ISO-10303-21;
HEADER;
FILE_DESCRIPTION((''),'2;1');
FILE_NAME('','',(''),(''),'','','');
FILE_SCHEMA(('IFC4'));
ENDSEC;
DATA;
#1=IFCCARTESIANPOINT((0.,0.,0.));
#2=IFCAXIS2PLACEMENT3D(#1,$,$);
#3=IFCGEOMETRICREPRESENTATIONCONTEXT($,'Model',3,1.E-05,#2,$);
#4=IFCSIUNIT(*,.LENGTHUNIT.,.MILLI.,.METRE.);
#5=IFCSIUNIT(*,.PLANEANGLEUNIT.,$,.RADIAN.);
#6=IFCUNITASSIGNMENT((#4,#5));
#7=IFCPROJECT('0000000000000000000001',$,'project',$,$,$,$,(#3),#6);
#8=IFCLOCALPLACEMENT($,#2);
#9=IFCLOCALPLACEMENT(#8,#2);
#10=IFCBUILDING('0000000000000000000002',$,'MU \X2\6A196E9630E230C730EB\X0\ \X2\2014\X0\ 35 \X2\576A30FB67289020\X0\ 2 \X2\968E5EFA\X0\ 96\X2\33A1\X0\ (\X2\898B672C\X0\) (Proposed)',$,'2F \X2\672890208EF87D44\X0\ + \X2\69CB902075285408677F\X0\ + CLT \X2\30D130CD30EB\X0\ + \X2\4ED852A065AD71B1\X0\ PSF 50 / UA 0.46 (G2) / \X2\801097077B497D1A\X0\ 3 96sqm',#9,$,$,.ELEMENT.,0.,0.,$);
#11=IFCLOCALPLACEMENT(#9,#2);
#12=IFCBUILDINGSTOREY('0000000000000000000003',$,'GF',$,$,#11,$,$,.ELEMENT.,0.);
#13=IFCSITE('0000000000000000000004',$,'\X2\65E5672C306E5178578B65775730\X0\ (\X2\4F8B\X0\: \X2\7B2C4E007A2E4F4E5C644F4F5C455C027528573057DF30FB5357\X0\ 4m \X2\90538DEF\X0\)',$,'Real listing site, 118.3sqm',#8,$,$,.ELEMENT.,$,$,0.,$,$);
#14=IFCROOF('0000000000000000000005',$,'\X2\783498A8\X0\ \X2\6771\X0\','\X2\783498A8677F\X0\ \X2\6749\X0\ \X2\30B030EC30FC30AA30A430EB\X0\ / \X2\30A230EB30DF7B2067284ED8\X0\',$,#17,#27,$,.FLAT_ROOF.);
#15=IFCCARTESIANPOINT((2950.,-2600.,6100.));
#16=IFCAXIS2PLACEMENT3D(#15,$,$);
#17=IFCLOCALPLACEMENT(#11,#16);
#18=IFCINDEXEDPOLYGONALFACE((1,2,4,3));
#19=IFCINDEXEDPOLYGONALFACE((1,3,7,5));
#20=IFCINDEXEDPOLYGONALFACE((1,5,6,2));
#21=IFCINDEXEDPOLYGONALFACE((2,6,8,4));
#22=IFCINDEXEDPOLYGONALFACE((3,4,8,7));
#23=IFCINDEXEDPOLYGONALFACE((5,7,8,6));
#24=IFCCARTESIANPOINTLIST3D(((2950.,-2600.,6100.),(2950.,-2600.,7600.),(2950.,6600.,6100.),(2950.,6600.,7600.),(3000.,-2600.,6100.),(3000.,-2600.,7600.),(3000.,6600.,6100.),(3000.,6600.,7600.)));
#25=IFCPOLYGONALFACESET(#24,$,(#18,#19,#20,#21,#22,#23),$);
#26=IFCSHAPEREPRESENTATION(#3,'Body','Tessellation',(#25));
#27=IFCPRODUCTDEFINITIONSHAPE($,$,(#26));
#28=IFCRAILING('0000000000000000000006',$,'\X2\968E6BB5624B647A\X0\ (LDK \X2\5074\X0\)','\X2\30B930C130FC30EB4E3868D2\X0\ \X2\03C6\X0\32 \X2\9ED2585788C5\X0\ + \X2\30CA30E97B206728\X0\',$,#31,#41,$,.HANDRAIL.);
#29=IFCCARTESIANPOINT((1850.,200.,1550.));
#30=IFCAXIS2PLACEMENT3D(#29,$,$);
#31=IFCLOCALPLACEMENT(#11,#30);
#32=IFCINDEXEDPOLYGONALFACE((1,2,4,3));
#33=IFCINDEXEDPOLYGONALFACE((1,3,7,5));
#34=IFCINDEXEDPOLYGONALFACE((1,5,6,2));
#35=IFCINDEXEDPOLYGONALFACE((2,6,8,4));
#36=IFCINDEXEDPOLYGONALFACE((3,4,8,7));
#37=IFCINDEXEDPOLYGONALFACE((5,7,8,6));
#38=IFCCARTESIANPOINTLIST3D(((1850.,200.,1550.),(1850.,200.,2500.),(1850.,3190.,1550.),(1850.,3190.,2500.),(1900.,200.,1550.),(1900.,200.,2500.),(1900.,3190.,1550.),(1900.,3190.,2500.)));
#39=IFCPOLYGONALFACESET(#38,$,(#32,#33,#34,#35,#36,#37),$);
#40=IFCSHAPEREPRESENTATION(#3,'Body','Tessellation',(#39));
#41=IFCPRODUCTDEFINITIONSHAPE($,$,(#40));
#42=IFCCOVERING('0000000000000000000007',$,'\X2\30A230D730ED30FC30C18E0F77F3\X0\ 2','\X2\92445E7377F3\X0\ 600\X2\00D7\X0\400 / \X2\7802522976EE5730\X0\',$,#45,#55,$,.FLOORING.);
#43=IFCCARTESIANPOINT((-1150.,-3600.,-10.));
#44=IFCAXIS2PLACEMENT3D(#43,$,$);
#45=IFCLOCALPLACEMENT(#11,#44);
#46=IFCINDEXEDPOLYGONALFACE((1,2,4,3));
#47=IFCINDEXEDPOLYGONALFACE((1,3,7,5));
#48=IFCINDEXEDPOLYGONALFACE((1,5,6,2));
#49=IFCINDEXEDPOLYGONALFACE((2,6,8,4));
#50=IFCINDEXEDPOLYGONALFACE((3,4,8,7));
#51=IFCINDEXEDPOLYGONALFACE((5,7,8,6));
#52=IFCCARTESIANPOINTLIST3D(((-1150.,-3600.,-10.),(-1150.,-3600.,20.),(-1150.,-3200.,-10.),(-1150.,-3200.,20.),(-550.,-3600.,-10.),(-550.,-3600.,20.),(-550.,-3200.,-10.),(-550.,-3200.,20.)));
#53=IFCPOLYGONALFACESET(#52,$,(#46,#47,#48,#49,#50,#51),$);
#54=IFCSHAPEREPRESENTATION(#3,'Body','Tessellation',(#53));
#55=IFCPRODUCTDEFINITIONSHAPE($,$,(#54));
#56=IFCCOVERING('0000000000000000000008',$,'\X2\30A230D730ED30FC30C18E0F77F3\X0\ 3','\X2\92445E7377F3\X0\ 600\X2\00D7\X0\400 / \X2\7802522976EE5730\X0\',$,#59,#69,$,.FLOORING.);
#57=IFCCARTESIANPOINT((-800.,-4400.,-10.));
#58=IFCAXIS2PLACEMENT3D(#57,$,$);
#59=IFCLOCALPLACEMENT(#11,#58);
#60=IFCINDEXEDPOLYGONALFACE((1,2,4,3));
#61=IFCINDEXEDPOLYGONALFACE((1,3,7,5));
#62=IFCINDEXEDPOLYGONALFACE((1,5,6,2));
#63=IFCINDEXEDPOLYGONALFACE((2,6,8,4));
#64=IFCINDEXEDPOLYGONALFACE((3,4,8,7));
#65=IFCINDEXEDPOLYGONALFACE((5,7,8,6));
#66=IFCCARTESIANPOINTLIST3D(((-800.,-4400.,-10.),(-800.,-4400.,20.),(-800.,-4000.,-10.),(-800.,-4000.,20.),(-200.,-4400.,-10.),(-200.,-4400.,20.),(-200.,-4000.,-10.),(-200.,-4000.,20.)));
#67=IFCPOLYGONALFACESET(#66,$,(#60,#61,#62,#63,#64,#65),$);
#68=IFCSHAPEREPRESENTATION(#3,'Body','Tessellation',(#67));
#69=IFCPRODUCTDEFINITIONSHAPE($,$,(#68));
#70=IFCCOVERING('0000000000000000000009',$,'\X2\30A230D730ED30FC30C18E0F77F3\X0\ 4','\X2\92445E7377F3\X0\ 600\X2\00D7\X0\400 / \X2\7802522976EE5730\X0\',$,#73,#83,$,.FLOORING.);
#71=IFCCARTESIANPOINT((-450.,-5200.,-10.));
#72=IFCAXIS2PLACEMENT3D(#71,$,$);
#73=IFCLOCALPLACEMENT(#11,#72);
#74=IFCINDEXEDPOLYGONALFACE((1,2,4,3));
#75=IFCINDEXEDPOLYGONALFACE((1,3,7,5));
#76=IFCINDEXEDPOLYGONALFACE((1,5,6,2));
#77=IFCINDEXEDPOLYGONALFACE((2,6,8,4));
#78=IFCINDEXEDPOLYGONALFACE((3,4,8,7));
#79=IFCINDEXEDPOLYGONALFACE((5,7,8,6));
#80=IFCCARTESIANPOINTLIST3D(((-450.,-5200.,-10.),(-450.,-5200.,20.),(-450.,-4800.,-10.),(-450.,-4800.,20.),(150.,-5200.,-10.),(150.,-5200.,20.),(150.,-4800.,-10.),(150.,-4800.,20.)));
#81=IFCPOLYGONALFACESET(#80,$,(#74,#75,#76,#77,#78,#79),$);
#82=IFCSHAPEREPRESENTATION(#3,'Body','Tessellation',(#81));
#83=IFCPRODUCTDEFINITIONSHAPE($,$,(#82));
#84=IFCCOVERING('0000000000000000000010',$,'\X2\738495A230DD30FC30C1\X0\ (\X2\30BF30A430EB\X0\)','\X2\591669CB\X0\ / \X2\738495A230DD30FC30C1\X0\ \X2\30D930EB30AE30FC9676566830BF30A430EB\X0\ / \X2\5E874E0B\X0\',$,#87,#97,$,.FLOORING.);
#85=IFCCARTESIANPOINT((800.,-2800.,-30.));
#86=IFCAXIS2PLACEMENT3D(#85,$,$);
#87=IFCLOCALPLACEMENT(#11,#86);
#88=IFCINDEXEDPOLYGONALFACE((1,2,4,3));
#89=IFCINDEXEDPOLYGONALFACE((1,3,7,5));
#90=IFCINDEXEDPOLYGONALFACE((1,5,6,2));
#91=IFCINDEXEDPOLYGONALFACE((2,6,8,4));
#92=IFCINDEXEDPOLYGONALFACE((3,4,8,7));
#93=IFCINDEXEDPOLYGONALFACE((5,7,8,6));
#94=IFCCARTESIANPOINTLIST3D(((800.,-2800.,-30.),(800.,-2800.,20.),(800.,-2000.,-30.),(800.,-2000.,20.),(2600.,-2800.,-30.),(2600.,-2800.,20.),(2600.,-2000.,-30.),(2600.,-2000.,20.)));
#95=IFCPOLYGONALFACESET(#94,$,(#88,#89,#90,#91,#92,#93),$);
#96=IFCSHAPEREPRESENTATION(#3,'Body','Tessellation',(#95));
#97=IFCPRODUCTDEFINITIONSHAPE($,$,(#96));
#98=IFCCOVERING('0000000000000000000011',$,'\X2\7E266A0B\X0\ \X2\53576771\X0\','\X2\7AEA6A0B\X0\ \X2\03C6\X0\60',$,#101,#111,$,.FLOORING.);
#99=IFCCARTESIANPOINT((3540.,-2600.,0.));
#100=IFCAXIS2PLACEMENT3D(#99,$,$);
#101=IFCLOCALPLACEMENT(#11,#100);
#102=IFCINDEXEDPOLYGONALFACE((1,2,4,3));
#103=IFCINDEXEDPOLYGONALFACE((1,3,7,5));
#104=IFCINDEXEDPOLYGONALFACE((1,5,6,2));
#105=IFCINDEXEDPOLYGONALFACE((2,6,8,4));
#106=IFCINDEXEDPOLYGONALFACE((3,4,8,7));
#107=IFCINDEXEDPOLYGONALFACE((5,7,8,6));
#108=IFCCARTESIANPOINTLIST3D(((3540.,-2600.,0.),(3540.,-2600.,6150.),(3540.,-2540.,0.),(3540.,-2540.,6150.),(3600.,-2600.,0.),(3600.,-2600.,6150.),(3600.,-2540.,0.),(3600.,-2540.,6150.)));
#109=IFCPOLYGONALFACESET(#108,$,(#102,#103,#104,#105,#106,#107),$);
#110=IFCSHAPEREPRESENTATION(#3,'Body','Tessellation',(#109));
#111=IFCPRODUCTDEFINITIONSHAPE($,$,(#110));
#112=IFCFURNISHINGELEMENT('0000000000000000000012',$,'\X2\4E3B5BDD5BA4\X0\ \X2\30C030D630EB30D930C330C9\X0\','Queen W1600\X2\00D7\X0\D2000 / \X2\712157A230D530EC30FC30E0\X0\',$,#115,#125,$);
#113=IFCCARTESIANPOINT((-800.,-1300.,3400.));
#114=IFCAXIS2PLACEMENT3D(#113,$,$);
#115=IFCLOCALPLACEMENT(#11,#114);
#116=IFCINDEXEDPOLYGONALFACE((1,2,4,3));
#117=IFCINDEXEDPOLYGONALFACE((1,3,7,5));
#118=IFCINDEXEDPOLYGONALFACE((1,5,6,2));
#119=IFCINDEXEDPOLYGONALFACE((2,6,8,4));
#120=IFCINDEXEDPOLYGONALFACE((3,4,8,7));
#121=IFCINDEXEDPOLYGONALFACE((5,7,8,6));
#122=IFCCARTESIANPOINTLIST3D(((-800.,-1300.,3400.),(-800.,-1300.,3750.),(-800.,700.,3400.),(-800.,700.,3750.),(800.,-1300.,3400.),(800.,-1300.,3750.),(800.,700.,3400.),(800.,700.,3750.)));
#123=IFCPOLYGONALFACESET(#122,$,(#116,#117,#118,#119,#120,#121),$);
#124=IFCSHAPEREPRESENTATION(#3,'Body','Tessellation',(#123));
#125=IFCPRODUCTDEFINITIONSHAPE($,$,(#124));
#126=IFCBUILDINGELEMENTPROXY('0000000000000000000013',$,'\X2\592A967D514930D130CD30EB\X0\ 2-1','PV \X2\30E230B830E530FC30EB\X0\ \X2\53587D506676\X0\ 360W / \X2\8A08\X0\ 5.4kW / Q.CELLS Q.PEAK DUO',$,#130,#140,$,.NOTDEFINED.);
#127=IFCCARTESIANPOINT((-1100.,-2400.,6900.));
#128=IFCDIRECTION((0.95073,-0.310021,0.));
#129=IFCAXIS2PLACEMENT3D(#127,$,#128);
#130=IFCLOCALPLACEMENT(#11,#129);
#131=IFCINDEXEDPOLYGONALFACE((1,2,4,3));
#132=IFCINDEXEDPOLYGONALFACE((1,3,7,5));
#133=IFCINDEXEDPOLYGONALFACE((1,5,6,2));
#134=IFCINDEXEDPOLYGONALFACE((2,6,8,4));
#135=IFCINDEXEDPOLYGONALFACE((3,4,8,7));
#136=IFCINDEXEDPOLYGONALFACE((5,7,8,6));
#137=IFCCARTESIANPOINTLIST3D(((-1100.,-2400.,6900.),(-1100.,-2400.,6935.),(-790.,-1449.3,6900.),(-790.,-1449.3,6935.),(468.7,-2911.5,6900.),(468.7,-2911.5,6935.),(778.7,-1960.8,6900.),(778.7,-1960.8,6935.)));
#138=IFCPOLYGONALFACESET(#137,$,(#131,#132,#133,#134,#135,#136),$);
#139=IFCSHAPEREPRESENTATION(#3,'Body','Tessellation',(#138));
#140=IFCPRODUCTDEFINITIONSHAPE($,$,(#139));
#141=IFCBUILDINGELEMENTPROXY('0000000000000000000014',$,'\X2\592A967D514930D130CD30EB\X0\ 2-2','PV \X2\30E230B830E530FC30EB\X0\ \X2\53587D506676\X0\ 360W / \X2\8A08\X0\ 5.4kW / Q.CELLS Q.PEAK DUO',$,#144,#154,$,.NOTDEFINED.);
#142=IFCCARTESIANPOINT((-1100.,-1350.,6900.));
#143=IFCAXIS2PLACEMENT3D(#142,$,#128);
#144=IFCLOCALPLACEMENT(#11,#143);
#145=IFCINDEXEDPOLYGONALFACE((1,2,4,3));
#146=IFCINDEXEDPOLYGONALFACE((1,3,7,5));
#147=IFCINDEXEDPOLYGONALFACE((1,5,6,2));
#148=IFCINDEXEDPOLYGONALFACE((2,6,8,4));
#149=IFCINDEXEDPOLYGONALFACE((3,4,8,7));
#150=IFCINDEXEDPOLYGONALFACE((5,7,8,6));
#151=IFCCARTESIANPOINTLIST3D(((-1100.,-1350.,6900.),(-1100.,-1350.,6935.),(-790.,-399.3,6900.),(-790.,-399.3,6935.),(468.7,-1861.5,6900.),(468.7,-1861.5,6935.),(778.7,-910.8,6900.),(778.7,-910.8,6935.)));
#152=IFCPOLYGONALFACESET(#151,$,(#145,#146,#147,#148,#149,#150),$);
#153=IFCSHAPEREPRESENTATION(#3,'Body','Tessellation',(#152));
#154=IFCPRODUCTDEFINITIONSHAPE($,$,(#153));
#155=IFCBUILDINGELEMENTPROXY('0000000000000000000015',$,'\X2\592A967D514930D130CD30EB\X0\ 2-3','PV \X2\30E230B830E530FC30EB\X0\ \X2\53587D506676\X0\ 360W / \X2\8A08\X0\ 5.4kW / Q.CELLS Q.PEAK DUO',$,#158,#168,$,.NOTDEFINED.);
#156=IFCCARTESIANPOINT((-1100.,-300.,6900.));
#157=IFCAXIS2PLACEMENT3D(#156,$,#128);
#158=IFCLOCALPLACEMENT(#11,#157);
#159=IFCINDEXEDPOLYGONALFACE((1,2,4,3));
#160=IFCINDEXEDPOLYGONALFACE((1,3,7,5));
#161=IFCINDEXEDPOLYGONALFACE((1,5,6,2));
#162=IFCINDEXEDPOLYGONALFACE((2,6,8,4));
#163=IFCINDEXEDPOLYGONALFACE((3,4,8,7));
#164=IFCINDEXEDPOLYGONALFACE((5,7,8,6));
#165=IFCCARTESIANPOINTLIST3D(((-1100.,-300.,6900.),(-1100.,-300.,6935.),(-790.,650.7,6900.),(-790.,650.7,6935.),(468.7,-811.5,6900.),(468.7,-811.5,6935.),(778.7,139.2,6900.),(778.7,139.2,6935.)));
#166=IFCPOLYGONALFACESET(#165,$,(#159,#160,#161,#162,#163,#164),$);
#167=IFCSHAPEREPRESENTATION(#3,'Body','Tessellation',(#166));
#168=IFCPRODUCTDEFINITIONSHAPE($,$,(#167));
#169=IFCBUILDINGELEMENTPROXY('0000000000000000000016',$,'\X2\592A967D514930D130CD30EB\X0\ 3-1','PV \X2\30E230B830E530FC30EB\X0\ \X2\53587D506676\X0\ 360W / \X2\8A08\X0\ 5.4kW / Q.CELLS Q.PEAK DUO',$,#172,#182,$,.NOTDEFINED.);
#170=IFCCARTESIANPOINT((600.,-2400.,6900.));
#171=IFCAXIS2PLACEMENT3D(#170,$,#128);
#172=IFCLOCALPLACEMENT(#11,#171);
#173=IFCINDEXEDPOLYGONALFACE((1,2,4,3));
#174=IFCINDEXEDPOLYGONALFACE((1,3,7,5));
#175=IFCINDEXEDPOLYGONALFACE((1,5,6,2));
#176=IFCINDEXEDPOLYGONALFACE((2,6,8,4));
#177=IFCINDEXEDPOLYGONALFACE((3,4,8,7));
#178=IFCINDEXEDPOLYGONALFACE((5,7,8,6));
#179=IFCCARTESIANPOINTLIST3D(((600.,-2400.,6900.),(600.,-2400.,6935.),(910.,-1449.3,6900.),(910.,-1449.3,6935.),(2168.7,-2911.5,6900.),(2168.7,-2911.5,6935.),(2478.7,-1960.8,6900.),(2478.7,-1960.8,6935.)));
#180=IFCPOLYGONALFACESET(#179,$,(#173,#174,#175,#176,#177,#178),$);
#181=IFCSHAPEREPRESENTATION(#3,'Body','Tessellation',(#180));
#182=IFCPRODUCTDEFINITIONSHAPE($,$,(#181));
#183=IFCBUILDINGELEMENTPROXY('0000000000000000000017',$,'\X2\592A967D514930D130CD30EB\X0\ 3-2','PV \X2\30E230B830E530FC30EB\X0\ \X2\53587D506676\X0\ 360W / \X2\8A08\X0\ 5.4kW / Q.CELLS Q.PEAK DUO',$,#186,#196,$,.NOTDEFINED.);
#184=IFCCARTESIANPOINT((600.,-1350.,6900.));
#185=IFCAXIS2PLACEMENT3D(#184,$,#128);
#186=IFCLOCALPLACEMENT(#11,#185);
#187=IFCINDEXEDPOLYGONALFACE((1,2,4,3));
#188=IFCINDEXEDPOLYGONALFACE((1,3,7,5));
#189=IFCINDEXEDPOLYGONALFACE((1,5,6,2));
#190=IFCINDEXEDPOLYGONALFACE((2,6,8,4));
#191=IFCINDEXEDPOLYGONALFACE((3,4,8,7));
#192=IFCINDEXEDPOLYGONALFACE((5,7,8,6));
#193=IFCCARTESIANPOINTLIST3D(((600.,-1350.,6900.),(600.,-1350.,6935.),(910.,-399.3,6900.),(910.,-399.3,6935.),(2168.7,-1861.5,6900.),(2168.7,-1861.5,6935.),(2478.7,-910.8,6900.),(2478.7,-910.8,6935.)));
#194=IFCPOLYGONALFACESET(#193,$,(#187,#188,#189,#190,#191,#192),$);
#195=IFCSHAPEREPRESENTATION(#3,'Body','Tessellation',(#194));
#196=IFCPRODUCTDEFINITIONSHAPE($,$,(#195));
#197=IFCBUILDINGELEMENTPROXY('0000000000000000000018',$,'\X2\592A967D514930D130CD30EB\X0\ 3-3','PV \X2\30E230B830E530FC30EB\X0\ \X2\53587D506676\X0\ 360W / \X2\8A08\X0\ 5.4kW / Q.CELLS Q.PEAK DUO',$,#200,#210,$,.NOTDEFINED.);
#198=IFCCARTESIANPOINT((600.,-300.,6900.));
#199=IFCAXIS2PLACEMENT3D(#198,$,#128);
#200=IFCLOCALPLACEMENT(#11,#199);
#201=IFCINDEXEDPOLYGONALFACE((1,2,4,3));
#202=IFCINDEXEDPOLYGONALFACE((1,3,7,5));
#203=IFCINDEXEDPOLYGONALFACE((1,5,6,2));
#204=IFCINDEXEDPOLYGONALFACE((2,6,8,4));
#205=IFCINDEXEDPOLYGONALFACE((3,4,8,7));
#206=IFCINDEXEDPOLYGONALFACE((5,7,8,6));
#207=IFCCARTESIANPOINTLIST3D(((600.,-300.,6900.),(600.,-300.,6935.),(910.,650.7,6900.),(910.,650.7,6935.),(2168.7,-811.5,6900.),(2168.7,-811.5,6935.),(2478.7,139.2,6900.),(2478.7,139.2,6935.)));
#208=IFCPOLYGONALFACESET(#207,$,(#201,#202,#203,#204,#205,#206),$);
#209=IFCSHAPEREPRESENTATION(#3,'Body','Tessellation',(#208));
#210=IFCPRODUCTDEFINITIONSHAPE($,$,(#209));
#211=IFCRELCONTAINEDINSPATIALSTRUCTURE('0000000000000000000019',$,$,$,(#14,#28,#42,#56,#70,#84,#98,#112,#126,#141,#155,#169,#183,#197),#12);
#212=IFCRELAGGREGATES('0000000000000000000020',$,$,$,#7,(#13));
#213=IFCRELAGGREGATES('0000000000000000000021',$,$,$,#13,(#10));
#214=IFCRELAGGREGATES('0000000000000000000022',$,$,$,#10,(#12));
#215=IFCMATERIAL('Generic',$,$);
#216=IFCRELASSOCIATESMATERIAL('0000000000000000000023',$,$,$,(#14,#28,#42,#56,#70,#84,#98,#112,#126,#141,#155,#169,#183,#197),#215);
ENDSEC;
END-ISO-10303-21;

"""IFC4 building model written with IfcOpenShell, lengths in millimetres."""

from ifc_helpers import new_model, si_unit, frame, frame_2d, origin, place, context, project, spatial, rectangle, extrude, material, element, save


model = new_model("IFC4")

# Units and contexts
model_context = context("Model", 3, precision=1e-05, world=origin())
ifc_project = project(units=[si_unit("LENGTHUNIT", "METRE", prefix="MILLI"), si_unit("PLANEANGLEUNIT", "RADIAN")], contexts=[model_context])

# Site, building, storey
site_placement = place(None, origin())
site = spatial("IfcSite", under=ifc_project, at=site_placement, Name="日本の典型敷地 (例: 第一種低層住居専用地域・南 4m 道路)", ObjectType="Real listing site, 118.3sqm", CompositionType="ELEMENT", RefElevation=0.0)
building_placement = place(site_placement, origin())
building = spatial("IfcBuilding", under=site, at=building_placement, Name="MU 標準モデル — 35 坪・木造 2 階建 96㎡ (見本) (Proposed)", ObjectType="2F 木造軸組 + 構造用合板 + CLT パネル + 付加断熱 PSF 50 / UA 0.46 (G2) / 耐震等級 3 96sqm", CompositionType="ELEMENT", ElevationOfRefHeight=0.0, ElevationOfTerrain=0.0)
storey_placement = place(building_placement, origin())
storey = spatial("IfcBuildingStorey", under=building, at=storey_placement, Name="GF", CompositionType="ELEMENT", Elevation=0.0)

# Shared definitions
ifc_material_1 = material(Name="Generic")

# Roof
roof_placement = place(storey_placement, frame((2950.0, -2600.0, 6100.0)))
element("IfcRoof", 1, at=roof_placement, inside=storey, material=ifc_material_1, Name="破風 東", Description="破風板 杉 グレーオイル / アルミ笠木付", PredefinedType="FLAT_ROOF", context=model_context, shape_type="SweptSolid", body=[
    extrude(rectangle(XDim=50.0, YDim=9200.0, at=frame_2d((25.0, 4600.0))), frame((2950.0, -2600.0, 6100.0)), (0.0, 0.0, 1.0), 1500.0),
])

# Railing
railing_placement = place(storey_placement, frame((1850.0, 200.0, 1550.0)))
element("IfcRailing", 2, at=railing_placement, inside=storey, material=ifc_material_1, Name="階段手摺 (LDK 側)", Description="スチール丸棒 φ32 黒塗装 + ナラ笠木", PredefinedType="HANDRAIL", context=model_context, shape_type="SweptSolid", body=[
    extrude(rectangle(XDim=50.0, YDim=2990.0, at=frame_2d((25.0, 1495.0))), frame((1850.0, 200.0, 1550.0)), (0.0, 0.0, 1.0), 950.0),
])

# Coverings
covering_1_placement = place(storey_placement, frame((-1150.0, -3600.0, -10.0)))
element("IfcCovering", 3, at=covering_1_placement, inside=storey, material=ifc_material_1, Name="アプローチ踏石 2", Description="鉄平石 600×400 / 砂利目地", PredefinedType="FLOORING", context=model_context, shape_type="SweptSolid", body=[
    extrude(rectangle(XDim=600.0, YDim=400.0, at=frame_2d((300.0, 200.0))), frame((-1150.0, -3600.0, -10.0)), (0.0, 0.0, 1.0), 30.0),
])
covering_2_placement = place(storey_placement, frame((-800.0, -4400.0, -10.0)))
element("IfcCovering", 4, at=covering_2_placement, inside=storey, material=ifc_material_1, Name="アプローチ踏石 3", Description="鉄平石 600×400 / 砂利目地", PredefinedType="FLOORING", context=model_context, shape_type="SweptSolid", body=[
    extrude(rectangle(XDim=600.0, YDim=400.0, at=frame_2d((300.0, 200.0))), frame((-800.0, -4400.0, -10.0)), (0.0, 0.0, 1.0), 30.0),
])
covering_3_placement = place(storey_placement, frame((-450.0, -5200.0, -10.0)))
element("IfcCovering", 5, at=covering_3_placement, inside=storey, material=ifc_material_1, Name="アプローチ踏石 4", Description="鉄平石 600×400 / 砂利目地", PredefinedType="FLOORING", context=model_context, shape_type="SweptSolid", body=[
    extrude(rectangle(XDim=600.0, YDim=400.0, at=frame_2d((300.0, 200.0))), frame((-450.0, -5200.0, -10.0)), (0.0, 0.0, 1.0), 30.0),
])
covering_4_placement = place(storey_placement, frame((800.0, -2800.0, -30.0)))
element("IfcCovering", 6, at=covering_4_placement, inside=storey, material=ifc_material_1, Name="玄関ポーチ (タイル)", Description="外構 / 玄関ポーチ ベルギー陶器タイル / 庇下", PredefinedType="FLOORING", context=model_context, shape_type="SweptSolid", body=[
    extrude(rectangle(XDim=1800.0, YDim=800.0, at=frame_2d((900.0, 400.0))), frame((800.0, -2800.0, -30.0)), (0.0, 0.0, 1.0), 50.0),
])
covering_5_placement = place(storey_placement, frame((3540.0, -2600.0, 0.0)))
element("IfcCovering", 7, at=covering_5_placement, inside=storey, material=ifc_material_1, Name="縦樋 南東", Description="竪樋 φ60", PredefinedType="FLOORING", context=model_context, shape_type="SweptSolid", body=[
    extrude(rectangle(XDim=60.0, YDim=60.0, at=frame_2d((30.0, 30.0))), frame((3540.0, -2600.0, 0.0)), (0.0, 0.0, 1.0), 6150.0),
])

# Furnishing element
furnishing_placement = place(storey_placement, frame((-800.0, -1300.0, 3400.0)))
element("IfcFurnishingElement", 8, at=furnishing_placement, inside=storey, material=ifc_material_1, Name="主寝室 ダブルベッド", Description="Queen W1600×D2000 / 無垢フレーム", context=model_context, shape_type="SweptSolid", body=[
    extrude(rectangle(XDim=1600.0, YDim=2000.0, at=frame_2d((800.0, 1000.0))), frame((-800.0, -1300.0, 3400.0)), (0.0, 0.0, 1.0), 350.0),
])

# Building element proxies
proxy_1_placement = place(storey_placement, frame((-1100.0, -2400.0, 6900.0), x_axis=(0.95073, -0.310021, 0.0)))
element("IfcBuildingElementProxy", 9, at=proxy_1_placement, inside=storey, material=ifc_material_1, Name="太陽光パネル 2-1", Description="PV モジュール 単結晶 360W / 計 5.4kW / Q.CELLS Q.PEAK DUO", PredefinedType="NOTDEFINED", context=model_context, shape_type="SweptSolid", body=[
    extrude(rectangle(XDim=1650.0, YDim=1000.0, at=frame_2d((825.0, 500.0))), frame((-1100.0, -2400.0, 6900.0), x_axis=(0.95073, -0.310021, 0.0)), (0.0, 0.0, 1.0), 35.0),
])
proxy_2_placement = place(storey_placement, frame((-1100.0, -1350.0, 6900.0), x_axis=(0.95073, -0.310021, 0.0)))
element("IfcBuildingElementProxy", 10, at=proxy_2_placement, inside=storey, material=ifc_material_1, Name="太陽光パネル 2-2", Description="PV モジュール 単結晶 360W / 計 5.4kW / Q.CELLS Q.PEAK DUO", PredefinedType="NOTDEFINED", context=model_context, shape_type="SweptSolid", body=[
    extrude(rectangle(XDim=1650.0, YDim=1000.0, at=frame_2d((825.0, 500.0))), frame((-1100.0, -1350.0, 6900.0), x_axis=(0.95073, -0.310021, 0.0)), (0.0, 0.0, 1.0), 35.0),
])
proxy_3_placement = place(storey_placement, frame((-1100.0, -300.0, 6900.0), x_axis=(0.95073, -0.310021, 0.0)))
element("IfcBuildingElementProxy", 11, at=proxy_3_placement, inside=storey, material=ifc_material_1, Name="太陽光パネル 2-3", Description="PV モジュール 単結晶 360W / 計 5.4kW / Q.CELLS Q.PEAK DUO", PredefinedType="NOTDEFINED", context=model_context, shape_type="SweptSolid", body=[
    extrude(rectangle(XDim=1650.0, YDim=1000.0, at=frame_2d((825.0, 500.0))), frame((-1100.0, -300.0, 6900.0), x_axis=(0.95073, -0.310021, 0.0)), (0.0, 0.0, 1.0), 35.0),
])
proxy_4_placement = place(storey_placement, frame((600.0, -2400.0, 6900.0), x_axis=(0.95073, -0.310021, 0.0)))
element("IfcBuildingElementProxy", 12, at=proxy_4_placement, inside=storey, material=ifc_material_1, Name="太陽光パネル 3-1", Description="PV モジュール 単結晶 360W / 計 5.4kW / Q.CELLS Q.PEAK DUO", PredefinedType="NOTDEFINED", context=model_context, shape_type="SweptSolid", body=[
    extrude(rectangle(XDim=1650.0, YDim=1000.0, at=frame_2d((825.0, 500.0))), frame((600.0, -2400.0, 6900.0), x_axis=(0.95073, -0.310021, 0.0)), (0.0, 0.0, 1.0), 35.0),
])
proxy_5_placement = place(storey_placement, frame((600.0, -1350.0, 6900.0), x_axis=(0.95073, -0.310021, 0.0)))
element("IfcBuildingElementProxy", 13, at=proxy_5_placement, inside=storey, material=ifc_material_1, Name="太陽光パネル 3-2", Description="PV モジュール 単結晶 360W / 計 5.4kW / Q.CELLS Q.PEAK DUO", PredefinedType="NOTDEFINED", context=model_context, shape_type="SweptSolid", body=[
    extrude(rectangle(XDim=1650.0, YDim=1000.0, at=frame_2d((825.0, 500.0))), frame((600.0, -1350.0, 6900.0), x_axis=(0.95073, -0.310021, 0.0)), (0.0, 0.0, 1.0), 35.0),
])
proxy_6_placement = place(storey_placement, frame((600.0, -300.0, 6900.0), x_axis=(0.95073, -0.310021, 0.0)))
element("IfcBuildingElementProxy", 14, at=proxy_6_placement, inside=storey, material=ifc_material_1, Name="太陽光パネル 3-3", Description="PV モジュール 単結晶 360W / 計 5.4kW / Q.CELLS Q.PEAK DUO", PredefinedType="NOTDEFINED", context=model_context, shape_type="SweptSolid", body=[
    extrude(rectangle(XDim=1650.0, YDim=1000.0, at=frame_2d((825.0, 500.0))), frame((600.0, -300.0, 6900.0), x_axis=(0.95073, -0.310021, 0.0)), (0.0, 0.0, 1.0), 35.0),
])

save(model, "model.ifc")
